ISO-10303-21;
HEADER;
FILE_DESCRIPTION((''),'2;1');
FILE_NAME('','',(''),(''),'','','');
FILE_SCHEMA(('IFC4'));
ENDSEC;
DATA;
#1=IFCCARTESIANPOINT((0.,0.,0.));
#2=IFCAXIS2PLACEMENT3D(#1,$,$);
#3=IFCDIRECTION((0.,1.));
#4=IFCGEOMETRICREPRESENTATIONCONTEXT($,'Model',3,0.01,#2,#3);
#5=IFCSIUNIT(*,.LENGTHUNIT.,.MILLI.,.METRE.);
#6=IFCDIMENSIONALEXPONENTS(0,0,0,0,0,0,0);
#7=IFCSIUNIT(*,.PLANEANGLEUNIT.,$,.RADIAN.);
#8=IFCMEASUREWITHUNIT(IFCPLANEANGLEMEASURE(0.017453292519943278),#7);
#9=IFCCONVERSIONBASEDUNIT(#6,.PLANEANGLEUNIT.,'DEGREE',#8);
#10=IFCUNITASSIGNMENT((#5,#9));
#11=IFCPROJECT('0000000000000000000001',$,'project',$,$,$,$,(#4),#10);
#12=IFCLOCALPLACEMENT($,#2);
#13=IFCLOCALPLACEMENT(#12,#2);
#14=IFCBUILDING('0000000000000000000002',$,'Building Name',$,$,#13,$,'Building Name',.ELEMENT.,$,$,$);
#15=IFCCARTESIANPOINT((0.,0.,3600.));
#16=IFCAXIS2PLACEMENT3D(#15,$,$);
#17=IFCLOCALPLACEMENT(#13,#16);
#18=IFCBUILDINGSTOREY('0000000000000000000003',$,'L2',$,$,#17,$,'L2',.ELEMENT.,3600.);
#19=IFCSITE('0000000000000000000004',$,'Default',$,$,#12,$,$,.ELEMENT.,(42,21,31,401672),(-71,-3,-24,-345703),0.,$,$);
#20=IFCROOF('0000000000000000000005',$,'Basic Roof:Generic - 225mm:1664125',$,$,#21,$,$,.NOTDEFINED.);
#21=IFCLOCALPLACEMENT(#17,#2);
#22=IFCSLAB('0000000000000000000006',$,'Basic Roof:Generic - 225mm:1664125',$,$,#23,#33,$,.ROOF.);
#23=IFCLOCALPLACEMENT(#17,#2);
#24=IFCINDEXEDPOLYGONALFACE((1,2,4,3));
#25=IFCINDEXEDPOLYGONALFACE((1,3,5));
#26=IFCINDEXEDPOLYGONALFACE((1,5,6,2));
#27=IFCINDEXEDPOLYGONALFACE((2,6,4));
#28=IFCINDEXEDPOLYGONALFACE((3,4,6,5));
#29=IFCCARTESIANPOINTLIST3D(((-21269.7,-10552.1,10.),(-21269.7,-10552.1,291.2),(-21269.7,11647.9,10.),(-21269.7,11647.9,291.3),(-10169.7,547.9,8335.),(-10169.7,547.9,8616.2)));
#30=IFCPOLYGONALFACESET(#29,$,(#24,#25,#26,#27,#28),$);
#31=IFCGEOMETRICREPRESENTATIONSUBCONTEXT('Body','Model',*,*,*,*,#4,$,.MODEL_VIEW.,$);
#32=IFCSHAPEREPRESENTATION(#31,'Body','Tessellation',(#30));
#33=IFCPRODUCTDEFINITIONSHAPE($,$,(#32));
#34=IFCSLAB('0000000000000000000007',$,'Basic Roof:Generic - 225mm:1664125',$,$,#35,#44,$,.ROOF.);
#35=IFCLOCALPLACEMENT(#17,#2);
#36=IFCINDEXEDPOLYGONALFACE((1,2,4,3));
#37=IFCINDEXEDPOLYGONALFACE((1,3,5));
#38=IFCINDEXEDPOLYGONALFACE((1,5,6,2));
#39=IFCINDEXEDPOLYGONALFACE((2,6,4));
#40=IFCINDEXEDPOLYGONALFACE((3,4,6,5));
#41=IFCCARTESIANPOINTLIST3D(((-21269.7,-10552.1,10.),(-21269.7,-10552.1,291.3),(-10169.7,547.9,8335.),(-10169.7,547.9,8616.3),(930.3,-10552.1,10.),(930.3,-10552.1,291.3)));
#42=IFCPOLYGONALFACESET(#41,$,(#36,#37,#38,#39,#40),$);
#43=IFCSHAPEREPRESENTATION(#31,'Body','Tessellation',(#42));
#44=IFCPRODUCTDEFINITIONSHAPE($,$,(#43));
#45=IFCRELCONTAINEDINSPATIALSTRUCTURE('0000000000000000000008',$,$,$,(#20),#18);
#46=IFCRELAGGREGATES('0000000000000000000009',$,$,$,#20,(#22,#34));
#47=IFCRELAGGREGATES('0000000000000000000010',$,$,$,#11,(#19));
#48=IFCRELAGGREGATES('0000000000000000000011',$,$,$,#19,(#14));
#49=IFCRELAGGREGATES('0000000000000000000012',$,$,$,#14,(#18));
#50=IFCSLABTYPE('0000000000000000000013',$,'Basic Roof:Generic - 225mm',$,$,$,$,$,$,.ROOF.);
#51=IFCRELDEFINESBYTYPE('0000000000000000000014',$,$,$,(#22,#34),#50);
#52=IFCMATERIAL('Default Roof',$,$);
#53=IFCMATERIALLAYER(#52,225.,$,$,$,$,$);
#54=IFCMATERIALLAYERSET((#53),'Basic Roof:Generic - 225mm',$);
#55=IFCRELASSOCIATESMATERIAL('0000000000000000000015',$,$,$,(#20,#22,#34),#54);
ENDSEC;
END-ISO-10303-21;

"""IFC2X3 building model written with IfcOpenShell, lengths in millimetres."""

from ifc_helpers import new_model, entity, si_unit, converted_unit, direction, frame, origin, place, context, subcontext, project, spatial, polyline, outline, extrude, material, layer, layer_set, type_object, element, aggregate, save


model = new_model("IFC2X3")

# Units and contexts
model_context = context("Model", 3, precision=0.01, world=origin(), true_north=direction((0.0, 1.0)))
body_context = subcontext(model_context, "Body", "Model", "MODEL_VIEW")
ifc_project = project(units=[si_unit("LENGTHUNIT", "METRE", prefix="MILLI"), converted_unit("PLANEANGLEUNIT", "DEGREE", entity("IfcPlaneAngleMeasure", 0.017453292519943278), si_unit("PLANEANGLEUNIT", "RADIAN"), dimensions=[0, 0, 0, 0, 0, 0, 0])], contexts=[model_context])

# Site, building, storey
site_placement = place(None, origin())
site = spatial("IfcSite", under=ifc_project, at=site_placement, Name="Default", CompositionType="ELEMENT", RefLatitude=(42, 21, 31, 401672), RefLongitude=(-71, -3, -24, -345703), RefElevation=0.0)
building_placement = place(site_placement, origin())
building = spatial("IfcBuilding", under=site, at=building_placement, Name="Building Name", LongName="Building Name", CompositionType="ELEMENT")
storey_placement = place(building_placement, frame((0.0, 0.0, 3600.0)))
storey = spatial("IfcBuildingStorey", under=building, at=storey_placement, Name="L2", LongName="L2", CompositionType="ELEMENT", Elevation=3600.0)

# Roof, slabs
ifc_material = material(Name="Default Roof")
ifc_layer = layer(ifc_material, 225.0)
ifc_layer_set = layer_set([ifc_layer], Name="Basic Roof:Generic - 225mm")
roof_placement = place(storey_placement, frame((-21269.7, -10552.1, 10.0)))
roof = element("IfcRoof", 1, at=roof_placement, inside=storey, material=ifc_layer_set, Name="Basic Roof:Generic - 225mm:1664125", ShapeType="NOTDEFINED")
slab_type = type_object("IfcSlabType", Name="Basic Roof:Generic - 225mm", PredefinedType="ROOF")
slab_1_placement = place(roof_placement, origin())
slab_1 = element("IfcSlab", 2, at=slab_1_placement, type_object=slab_type, material=ifc_layer_set, Name="Basic Roof:Generic - 225mm:1664125", PredefinedType="ROOF", context=body_context, shape_type="SweptSolid", body=[
    extrude(outline(polyline([(6937.5, 0.0), (-6937.5, 11100.0), (-6937.5, -11100.0), (6937.5, 0.0)])), frame((5550.0, 11100.0, 4162.5), z_axis=(-0.6, 0.0, 0.8), x_axis=(0.8, 0.0, 0.6)), (0.6, 0.0, 0.8), 281.2),
])
slab_2_placement = place(roof_placement, origin())
slab_2 = element("IfcSlab", 3, at=slab_2_placement, type_object=slab_type, material=ifc_layer_set, Name="Basic Roof:Generic - 225mm:1664125", PredefinedType="ROOF", context=body_context, shape_type="SweptSolid", body=[
    extrude(outline(polyline([(-11100.0, -6937.5), (11100.0, -6937.5), (0.0, 6937.5), (-11100.0, -6937.5)])), frame((11100.0, 5550.0, 4162.5), z_axis=(0.0, -0.6, 0.8), x_axis=(1.0, 0.0, 0.0)), (0.0, 0.6, 0.8), 281.2),
])
aggregate(roof, [slab_1, slab_2])

save(model, "model.ifc")
